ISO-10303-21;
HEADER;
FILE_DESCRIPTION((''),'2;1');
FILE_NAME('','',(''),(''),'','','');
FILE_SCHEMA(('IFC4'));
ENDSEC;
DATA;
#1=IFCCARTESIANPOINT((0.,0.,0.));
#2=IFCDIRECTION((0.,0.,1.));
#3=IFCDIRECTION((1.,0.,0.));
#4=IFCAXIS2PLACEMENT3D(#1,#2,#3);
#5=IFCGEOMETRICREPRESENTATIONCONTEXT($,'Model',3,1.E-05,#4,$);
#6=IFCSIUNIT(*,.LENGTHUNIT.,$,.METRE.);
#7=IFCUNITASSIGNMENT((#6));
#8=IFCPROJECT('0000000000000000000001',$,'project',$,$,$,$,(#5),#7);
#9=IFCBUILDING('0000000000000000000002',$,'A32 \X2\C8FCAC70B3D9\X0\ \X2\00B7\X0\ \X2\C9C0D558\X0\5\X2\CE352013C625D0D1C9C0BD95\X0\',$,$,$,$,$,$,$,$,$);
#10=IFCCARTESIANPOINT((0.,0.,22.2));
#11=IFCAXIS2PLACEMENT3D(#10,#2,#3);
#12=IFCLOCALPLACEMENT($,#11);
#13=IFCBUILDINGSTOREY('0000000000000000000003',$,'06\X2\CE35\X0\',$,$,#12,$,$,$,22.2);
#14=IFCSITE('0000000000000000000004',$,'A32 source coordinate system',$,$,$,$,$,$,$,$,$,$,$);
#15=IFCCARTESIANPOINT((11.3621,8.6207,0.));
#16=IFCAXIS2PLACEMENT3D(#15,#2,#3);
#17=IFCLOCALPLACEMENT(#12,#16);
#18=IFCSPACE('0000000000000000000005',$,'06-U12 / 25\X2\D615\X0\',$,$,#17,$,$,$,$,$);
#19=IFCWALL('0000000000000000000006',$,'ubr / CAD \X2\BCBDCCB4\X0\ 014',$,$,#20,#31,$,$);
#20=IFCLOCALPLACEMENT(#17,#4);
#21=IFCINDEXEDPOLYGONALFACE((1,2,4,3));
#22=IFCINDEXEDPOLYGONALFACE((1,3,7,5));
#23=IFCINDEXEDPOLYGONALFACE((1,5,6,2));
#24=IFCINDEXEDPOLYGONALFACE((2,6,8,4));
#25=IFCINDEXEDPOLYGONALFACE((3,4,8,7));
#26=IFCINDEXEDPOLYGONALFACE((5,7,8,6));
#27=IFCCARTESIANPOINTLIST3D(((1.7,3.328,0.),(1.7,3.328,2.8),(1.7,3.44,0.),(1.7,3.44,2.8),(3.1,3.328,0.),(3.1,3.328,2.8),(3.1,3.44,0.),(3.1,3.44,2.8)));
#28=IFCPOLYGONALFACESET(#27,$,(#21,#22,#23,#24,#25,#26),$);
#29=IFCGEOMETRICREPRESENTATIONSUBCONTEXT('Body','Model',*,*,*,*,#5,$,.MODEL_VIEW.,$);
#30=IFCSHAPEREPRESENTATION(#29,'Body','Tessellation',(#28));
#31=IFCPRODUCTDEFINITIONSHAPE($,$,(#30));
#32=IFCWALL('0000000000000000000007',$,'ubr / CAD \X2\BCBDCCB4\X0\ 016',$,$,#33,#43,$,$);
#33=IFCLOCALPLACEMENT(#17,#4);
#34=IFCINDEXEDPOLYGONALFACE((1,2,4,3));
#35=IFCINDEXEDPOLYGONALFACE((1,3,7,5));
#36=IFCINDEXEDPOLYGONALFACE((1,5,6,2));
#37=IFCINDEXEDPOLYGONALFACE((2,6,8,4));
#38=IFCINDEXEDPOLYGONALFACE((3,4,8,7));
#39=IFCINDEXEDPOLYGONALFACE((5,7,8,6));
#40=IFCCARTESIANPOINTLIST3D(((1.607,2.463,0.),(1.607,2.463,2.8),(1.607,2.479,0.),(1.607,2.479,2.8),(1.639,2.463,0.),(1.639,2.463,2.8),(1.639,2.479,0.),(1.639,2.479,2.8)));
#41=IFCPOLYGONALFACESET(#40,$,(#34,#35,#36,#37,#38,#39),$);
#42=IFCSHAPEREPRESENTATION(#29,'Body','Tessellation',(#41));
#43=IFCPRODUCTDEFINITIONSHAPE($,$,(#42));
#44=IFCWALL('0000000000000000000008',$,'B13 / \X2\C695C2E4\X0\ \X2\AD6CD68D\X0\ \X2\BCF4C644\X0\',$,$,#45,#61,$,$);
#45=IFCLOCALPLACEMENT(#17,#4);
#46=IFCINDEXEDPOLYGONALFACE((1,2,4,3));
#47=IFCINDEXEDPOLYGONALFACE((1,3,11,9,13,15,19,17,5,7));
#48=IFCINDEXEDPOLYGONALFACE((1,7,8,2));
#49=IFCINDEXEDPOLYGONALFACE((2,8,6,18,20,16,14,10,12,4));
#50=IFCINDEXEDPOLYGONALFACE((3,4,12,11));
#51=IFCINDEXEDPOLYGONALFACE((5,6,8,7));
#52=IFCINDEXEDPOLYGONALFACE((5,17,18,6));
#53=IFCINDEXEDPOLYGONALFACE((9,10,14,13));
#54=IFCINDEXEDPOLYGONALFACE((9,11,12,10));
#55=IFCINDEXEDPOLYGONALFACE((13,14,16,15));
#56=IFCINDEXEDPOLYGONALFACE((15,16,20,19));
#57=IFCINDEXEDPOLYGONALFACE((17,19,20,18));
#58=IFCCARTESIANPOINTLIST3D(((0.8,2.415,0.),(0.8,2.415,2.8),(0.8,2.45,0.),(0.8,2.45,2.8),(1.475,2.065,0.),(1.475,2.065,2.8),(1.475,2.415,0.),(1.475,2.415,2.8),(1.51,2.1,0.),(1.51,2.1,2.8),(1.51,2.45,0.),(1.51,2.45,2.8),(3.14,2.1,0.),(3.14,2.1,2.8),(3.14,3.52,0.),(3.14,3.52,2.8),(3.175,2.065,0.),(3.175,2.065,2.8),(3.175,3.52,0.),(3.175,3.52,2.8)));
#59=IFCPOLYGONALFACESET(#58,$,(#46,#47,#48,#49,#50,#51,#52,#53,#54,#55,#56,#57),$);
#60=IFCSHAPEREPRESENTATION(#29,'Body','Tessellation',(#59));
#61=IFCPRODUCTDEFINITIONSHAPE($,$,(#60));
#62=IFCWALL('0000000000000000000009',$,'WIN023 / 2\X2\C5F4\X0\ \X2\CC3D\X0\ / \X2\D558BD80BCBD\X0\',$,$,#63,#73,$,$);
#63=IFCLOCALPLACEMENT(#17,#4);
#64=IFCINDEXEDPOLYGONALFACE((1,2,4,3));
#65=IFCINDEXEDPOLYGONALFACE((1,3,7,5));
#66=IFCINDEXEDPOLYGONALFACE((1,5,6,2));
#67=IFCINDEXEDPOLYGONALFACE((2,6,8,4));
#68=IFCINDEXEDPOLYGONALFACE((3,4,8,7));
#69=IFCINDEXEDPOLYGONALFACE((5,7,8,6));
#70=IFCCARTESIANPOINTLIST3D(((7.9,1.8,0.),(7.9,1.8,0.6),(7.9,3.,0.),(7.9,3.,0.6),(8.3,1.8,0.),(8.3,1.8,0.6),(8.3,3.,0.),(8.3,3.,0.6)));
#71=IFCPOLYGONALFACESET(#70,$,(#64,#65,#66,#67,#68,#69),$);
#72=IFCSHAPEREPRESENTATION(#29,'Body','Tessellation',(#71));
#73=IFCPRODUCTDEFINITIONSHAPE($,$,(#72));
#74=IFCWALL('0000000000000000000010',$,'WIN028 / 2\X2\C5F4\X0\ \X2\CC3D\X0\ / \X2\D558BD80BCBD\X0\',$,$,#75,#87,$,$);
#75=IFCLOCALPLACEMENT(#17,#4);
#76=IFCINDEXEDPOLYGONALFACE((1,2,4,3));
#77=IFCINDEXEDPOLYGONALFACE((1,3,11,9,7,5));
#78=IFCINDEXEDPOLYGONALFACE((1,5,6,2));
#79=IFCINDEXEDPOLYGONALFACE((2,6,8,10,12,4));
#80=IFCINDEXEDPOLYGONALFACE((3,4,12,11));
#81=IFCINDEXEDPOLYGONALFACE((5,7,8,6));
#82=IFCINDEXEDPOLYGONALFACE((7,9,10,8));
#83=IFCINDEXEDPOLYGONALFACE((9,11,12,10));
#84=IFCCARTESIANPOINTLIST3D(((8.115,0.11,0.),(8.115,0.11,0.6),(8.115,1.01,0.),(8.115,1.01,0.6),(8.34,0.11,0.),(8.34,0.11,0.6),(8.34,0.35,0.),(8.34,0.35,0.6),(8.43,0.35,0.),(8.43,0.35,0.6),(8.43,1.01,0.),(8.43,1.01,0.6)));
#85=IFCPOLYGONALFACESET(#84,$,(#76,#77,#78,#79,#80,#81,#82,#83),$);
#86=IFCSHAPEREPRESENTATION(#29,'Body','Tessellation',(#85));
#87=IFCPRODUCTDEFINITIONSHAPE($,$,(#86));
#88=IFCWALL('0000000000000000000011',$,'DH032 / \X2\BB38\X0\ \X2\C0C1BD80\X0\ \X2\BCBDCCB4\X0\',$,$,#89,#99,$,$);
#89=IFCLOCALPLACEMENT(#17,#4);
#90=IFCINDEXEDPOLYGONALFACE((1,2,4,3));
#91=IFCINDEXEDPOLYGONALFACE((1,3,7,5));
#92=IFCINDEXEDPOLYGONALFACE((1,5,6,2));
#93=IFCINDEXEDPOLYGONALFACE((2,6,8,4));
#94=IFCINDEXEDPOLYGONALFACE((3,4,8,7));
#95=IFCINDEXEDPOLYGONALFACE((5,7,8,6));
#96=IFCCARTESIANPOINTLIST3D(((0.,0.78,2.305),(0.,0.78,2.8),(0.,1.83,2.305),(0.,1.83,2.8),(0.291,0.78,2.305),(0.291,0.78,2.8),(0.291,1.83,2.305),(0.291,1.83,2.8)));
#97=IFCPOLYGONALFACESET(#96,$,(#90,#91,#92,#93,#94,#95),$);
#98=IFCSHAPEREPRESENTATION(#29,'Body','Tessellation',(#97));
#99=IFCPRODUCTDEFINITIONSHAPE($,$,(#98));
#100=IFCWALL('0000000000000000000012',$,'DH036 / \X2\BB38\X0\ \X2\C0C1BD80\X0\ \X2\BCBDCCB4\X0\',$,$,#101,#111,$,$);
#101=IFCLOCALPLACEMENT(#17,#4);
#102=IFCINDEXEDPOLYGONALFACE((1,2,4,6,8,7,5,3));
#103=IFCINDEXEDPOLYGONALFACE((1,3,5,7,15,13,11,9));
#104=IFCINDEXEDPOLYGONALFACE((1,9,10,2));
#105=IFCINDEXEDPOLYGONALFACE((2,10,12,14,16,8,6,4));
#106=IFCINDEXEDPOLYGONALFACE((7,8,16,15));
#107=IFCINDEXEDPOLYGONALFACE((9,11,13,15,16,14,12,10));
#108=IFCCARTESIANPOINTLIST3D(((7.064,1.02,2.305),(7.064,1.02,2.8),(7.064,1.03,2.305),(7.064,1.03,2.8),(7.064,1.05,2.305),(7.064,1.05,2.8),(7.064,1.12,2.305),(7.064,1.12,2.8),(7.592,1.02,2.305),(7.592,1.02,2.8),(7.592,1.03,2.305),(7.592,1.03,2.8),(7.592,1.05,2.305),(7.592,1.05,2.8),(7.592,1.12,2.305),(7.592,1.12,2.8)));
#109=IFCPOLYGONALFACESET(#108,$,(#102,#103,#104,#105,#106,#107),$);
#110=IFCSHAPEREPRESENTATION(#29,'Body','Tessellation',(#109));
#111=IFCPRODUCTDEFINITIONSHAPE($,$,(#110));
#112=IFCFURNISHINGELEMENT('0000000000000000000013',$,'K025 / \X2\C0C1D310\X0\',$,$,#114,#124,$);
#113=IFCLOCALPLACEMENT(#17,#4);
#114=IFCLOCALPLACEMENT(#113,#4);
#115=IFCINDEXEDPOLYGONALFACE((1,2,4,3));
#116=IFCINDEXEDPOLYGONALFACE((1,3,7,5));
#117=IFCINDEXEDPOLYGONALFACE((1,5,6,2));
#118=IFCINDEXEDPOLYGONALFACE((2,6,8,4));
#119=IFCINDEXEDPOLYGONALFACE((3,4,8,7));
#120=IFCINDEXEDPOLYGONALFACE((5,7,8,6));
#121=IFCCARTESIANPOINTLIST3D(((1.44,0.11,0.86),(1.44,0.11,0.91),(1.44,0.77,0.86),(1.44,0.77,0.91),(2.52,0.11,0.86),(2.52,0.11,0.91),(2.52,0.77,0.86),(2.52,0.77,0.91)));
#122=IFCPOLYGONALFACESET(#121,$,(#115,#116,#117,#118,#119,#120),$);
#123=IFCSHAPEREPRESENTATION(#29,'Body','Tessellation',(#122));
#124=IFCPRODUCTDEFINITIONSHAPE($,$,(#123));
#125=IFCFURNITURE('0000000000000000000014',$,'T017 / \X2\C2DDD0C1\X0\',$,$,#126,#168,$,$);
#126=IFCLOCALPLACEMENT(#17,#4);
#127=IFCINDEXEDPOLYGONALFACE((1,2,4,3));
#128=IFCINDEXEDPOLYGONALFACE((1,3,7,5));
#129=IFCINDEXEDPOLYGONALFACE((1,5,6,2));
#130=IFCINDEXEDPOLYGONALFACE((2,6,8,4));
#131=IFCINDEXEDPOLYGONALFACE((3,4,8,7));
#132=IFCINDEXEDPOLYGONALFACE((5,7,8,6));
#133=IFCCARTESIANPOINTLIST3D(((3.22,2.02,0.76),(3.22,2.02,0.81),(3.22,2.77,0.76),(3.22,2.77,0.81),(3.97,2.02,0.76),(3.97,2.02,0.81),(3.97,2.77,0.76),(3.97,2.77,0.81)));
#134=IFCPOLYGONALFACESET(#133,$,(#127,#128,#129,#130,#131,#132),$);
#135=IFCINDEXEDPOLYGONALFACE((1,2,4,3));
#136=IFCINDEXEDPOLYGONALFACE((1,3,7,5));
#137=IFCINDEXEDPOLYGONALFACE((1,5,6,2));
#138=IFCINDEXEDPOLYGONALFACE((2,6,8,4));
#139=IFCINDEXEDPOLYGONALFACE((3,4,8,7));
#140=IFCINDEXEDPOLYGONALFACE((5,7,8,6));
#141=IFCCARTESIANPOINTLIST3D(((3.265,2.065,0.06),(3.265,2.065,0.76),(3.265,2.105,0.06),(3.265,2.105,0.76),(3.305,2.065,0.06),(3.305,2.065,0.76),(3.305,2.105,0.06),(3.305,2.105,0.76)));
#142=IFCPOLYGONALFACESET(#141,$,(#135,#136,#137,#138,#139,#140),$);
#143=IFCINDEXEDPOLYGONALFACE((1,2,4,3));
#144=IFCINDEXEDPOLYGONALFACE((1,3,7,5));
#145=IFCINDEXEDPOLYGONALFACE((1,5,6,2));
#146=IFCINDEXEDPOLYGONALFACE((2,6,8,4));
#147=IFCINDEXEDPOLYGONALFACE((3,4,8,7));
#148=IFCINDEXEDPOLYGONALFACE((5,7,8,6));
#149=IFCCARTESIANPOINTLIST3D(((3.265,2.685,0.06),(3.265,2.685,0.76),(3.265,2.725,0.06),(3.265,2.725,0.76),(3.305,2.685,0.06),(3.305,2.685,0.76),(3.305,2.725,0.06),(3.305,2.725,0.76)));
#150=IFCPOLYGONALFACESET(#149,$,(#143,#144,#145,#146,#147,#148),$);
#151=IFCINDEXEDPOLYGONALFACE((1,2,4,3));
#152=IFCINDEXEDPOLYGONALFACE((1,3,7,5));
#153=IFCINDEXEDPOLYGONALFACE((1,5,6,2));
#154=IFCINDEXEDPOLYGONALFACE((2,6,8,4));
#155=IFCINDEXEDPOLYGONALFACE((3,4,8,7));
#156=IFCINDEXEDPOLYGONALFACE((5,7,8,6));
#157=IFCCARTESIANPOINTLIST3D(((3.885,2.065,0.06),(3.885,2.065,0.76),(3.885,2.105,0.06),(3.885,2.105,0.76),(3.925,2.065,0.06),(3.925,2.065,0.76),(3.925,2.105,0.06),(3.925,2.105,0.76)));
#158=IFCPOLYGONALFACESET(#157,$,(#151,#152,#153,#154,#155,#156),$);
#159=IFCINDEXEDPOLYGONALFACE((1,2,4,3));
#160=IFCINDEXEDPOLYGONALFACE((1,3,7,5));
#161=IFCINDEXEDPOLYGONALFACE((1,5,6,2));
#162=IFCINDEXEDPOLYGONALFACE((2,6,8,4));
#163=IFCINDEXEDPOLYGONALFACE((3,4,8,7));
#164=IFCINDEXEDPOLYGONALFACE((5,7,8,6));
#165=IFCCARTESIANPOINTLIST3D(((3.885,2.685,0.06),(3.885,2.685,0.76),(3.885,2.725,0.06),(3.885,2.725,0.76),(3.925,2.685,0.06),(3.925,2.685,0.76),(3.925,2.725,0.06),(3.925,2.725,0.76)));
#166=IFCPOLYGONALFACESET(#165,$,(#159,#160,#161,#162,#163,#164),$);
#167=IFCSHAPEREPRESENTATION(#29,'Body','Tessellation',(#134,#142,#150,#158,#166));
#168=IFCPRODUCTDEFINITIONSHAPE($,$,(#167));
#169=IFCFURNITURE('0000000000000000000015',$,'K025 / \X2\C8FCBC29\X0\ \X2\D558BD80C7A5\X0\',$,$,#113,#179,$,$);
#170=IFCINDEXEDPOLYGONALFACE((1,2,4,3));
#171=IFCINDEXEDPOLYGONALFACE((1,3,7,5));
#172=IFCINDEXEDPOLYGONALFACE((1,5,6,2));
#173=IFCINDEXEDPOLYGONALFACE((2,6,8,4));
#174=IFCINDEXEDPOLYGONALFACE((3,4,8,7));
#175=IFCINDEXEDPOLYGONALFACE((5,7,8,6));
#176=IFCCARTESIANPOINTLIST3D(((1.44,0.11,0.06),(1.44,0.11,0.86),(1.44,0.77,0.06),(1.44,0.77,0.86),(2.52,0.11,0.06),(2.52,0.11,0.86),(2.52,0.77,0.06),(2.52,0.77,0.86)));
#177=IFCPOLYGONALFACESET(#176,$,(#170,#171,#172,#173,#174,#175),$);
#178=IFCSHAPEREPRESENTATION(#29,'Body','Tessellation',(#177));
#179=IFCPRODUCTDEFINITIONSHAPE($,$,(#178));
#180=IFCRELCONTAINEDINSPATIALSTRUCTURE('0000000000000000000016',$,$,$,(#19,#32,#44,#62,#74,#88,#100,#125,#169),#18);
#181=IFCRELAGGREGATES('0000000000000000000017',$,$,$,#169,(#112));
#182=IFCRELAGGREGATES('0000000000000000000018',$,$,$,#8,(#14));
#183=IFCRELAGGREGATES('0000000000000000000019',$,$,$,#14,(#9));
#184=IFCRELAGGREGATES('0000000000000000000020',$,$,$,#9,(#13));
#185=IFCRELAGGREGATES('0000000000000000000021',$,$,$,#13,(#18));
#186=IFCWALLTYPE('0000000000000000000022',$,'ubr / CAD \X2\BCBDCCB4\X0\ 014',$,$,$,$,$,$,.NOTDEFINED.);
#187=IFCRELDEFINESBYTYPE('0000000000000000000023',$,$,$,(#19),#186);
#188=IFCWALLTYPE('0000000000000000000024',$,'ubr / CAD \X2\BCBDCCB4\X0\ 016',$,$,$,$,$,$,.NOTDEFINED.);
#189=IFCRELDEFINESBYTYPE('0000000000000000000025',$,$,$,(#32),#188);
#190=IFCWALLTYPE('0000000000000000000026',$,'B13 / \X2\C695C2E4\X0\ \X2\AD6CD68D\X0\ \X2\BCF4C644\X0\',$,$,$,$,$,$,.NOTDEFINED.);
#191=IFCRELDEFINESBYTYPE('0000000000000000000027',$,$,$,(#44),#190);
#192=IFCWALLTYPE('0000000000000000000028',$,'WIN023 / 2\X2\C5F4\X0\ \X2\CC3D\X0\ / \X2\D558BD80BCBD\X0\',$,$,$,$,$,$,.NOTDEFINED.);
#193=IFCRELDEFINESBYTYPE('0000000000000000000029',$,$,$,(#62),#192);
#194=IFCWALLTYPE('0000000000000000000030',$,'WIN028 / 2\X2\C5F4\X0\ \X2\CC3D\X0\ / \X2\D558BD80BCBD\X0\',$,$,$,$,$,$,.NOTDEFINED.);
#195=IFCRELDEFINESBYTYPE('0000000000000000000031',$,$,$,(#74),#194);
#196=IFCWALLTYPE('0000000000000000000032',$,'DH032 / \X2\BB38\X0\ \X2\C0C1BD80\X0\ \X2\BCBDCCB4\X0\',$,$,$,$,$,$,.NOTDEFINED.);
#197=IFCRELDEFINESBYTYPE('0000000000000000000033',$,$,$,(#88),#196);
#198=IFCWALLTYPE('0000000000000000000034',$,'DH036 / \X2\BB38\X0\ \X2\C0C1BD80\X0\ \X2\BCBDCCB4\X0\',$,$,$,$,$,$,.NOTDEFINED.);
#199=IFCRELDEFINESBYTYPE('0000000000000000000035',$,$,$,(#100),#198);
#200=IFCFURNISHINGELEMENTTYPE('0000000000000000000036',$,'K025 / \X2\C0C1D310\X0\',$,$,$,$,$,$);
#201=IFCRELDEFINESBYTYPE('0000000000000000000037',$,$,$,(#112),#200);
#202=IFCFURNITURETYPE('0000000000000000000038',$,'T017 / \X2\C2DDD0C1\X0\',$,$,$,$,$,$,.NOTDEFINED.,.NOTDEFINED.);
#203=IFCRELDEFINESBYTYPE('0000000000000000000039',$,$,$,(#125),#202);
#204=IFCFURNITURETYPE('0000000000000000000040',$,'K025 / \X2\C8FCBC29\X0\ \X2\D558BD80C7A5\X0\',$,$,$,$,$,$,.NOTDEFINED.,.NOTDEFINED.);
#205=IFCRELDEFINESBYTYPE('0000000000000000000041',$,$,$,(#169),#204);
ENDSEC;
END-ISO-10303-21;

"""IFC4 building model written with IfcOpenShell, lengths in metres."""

from ifc_helpers import new_model, si_unit, frame, origin, origin_with_axes, place, context, subcontext, project, spatial, polyline, outline, extrude, source, transform, mapped, type_object, type_shapes, element, aggregate, save


model = new_model("IFC4")

# Units and contexts
model_context = context("Model", 3, precision=1e-05, world=origin_with_axes())
body_context = subcontext(model_context, "Body", "Model", "MODEL_VIEW")
ifc_project = project(units=[si_unit("LENGTHUNIT", "METRE")], contexts=[model_context])

# Site, building, storey, space
site = spatial("IfcSite", under=ifc_project, Name="A32 source coordinate system")
building = spatial("IfcBuilding", under=site, Name="A32 주거동 · 지하5층–옥탑지붕")
storey_placement = place(None, frame((0.0, 0.0, 22.2), z_axis=(0.0, 0.0, 1.0), x_axis=(1.0, 0.0, 0.0)))
storey = spatial("IfcBuildingStorey", under=building, at=storey_placement, Name="06층", Elevation=22.2)
space_1_placement = place(storey_placement, frame((11.3621, 8.6207, 0.0), z_axis=(0.0, 0.0, 1.0), x_axis=(1.0, 0.0, 0.0)))
space_1 = spatial("IfcSpace", under=storey, at=space_1_placement, Name="06-U12 / 25형")

# Walls
wall_type_1 = type_object("IfcWallType", Name="ubr / CAD 벽체 014", PredefinedType="NOTDEFINED")
shared_shape_1 = source(origin(), body_context, "Body", "SweptSolid", [
    extrude(outline(polyline([(3.1, 3.44), (3.1, 3.328), (1.7, 3.328), (1.7, 3.44), (3.1, 3.44)])), origin(), (0.0, 0.0, 1.0), 2.8),
])
type_shapes(wall_type_1, [shared_shape_1])
wall_1_placement = place(space_1_placement, origin_with_axes())
element("IfcWall", 1, at=wall_1_placement, inside=space_1, type_object=wall_type_1, Name="ubr / CAD 벽체 014", context=body_context, shape_type="MappedRepresentation", body=[
    mapped(shared_shape_1, transform((0.0, 0.0, 0.0), scale=1.0)),
])
wall_type_2 = type_object("IfcWallType", Name="ubr / CAD 벽체 016", PredefinedType="NOTDEFINED")
shared_shape_2 = source(origin(), body_context, "Body", "SweptSolid", [
    extrude(outline(polyline([(1.639, 2.479), (1.639, 2.463), (1.607, 2.463), (1.607, 2.479), (1.639, 2.479)])), origin(), (0.0, 0.0, 1.0), 2.8),
])
type_shapes(wall_type_2, [shared_shape_2])
wall_2_placement = place(space_1_placement, origin_with_axes())
element("IfcWall", 2, at=wall_2_placement, inside=space_1, type_object=wall_type_2, Name="ubr / CAD 벽체 016", context=body_context, shape_type="MappedRepresentation", body=[
    mapped(shared_shape_2, transform((0.0, 0.0, 0.0), scale=1.0)),
])
wall_type_3 = type_object("IfcWallType", Name="B13 / 욕실 구획 보완", PredefinedType="NOTDEFINED")
shared_shape_3 = source(origin(), body_context, "Body", "SweptSolid", [
    extrude(outline(polyline([(0.8, 2.45), (1.51, 2.45), (1.51, 2.1), (3.14, 2.1), (3.14, 3.52), (3.175, 3.52), (3.175, 2.065), (1.475, 2.065), (1.475, 2.415), (0.8, 2.415), (0.8, 2.45)])), origin(), (0.0, 0.0, 1.0), 2.8),
])
type_shapes(wall_type_3, [shared_shape_3])
wall_3_placement = place(space_1_placement, origin_with_axes())
element("IfcWall", 3, at=wall_3_placement, inside=space_1, type_object=wall_type_3, Name="B13 / 욕실 구획 보완", context=body_context, shape_type="MappedRepresentation", body=[
    mapped(shared_shape_3, transform((0.0, 0.0, 0.0), scale=1.0)),
])
wall_type_4 = type_object("IfcWallType", Name="WIN023 / 2열 창 / 하부벽", PredefinedType="NOTDEFINED")
shared_shape_4 = source(origin(), body_context, "Body", "SweptSolid", [
    extrude(outline(polyline([(7.9, 1.8), (7.9, 3.0), (8.3, 3.0), (8.3, 1.8), (7.9, 1.8)])), origin(), (0.0, 0.0, 1.0), 0.6),
])
type_shapes(wall_type_4, [shared_shape_4])
wall_4_placement = place(space_1_placement, origin_with_axes())
element("IfcWall", 4, at=wall_4_placement, inside=space_1, type_object=wall_type_4, Name="WIN023 / 2열 창 / 하부벽", context=body_context, shape_type="MappedRepresentation", body=[
    mapped(shared_shape_4, transform((0.0, 0.0, 0.0), scale=1.0)),
])
wall_type_5 = type_object("IfcWallType", Name="WIN028 / 2열 창 / 하부벽", PredefinedType="NOTDEFINED")
shared_shape_5 = source(origin(), body_context, "Body", "SweptSolid", [
    extrude(outline(polyline([(8.34, 0.35), (8.34, 0.11), (8.115, 0.11), (8.115, 1.01), (8.43, 1.01), (8.43, 0.35), (8.34, 0.35)])), origin(), (0.0, 0.0, 1.0), 0.6),
])
type_shapes(wall_type_5, [shared_shape_5])
wall_5_placement = place(space_1_placement, origin_with_axes())
element("IfcWall", 5, at=wall_5_placement, inside=space_1, type_object=wall_type_5, Name="WIN028 / 2열 창 / 하부벽", context=body_context, shape_type="MappedRepresentation", body=[
    mapped(shared_shape_5, transform((0.0, 0.0, 0.0), scale=1.0)),
])
wall_type_6 = type_object("IfcWallType", Name="DH032 / 문 상부 벽체", PredefinedType="NOTDEFINED")
shared_shape_6 = source(origin(), body_context, "Body", "SweptSolid", [
    extrude(outline(polyline([(0.0, 1.83), (0.291, 1.83), (0.291, 0.78), (0.0, 0.78), (0.0, 1.83)])), frame((0.0, 0.0, 2.305)), (0.0, 0.0, 1.0), 0.495),
])
type_shapes(wall_type_6, [shared_shape_6])
wall_6_placement = place(space_1_placement, origin_with_axes())
element("IfcWall", 6, at=wall_6_placement, inside=space_1, type_object=wall_type_6, Name="DH032 / 문 상부 벽체", context=body_context, shape_type="MappedRepresentation", body=[
    mapped(shared_shape_6, transform((0.0, 0.0, 0.0), scale=1.0)),
])
wall_type_7 = type_object("IfcWallType", Name="DH036 / 문 상부 벽체", PredefinedType="NOTDEFINED")
shared_shape_7 = source(origin(), body_context, "Body", "SweptSolid", [
    extrude(outline(polyline([(7.064, 1.03), (7.064, 1.05), (7.064, 1.12), (7.592, 1.12), (7.592, 1.05), (7.592, 1.03), (7.592, 1.02), (7.064, 1.02), (7.064, 1.03)])), frame((0.0, 0.0, 2.305)), (0.0, 0.0, 1.0), 0.495),
])
type_shapes(wall_type_7, [shared_shape_7])
wall_7_placement = place(space_1_placement, origin_with_axes())
element("IfcWall", 7, at=wall_7_placement, inside=space_1, type_object=wall_type_7, Name="DH036 / 문 상부 벽체", context=body_context, shape_type="MappedRepresentation", body=[
    mapped(shared_shape_7, transform((0.0, 0.0, 0.0), scale=1.0)),
])

# Furnishing element
furnishing_element_type_1 = type_object("IfcFurnishingElementType", Name="K025 / 상판")
shared_shape_8 = source(origin(), body_context, "Body", "SweptSolid", [
    extrude(outline(polyline([(2.52, 0.77), (2.52, 0.11), (1.44, 0.11), (1.44, 0.77), (2.52, 0.77)])), frame((0.0, 0.0, 0.86)), (0.0, 0.0, 1.0), 0.05),
])
type_shapes(furnishing_element_type_1, [shared_shape_8])
furniture_1_placement = place(space_1_placement, origin_with_axes())
furnishing_1_placement = place(furniture_1_placement, origin_with_axes())
furnishing_1 = element("IfcFurnishingElement", 8, at=furnishing_1_placement, type_object=furnishing_element_type_1, Name="K025 / 상판", context=body_context, shape_type="MappedRepresentation", body=[
    mapped(shared_shape_8, transform((0.0, 0.0, 0.0), scale=1.0)),
])

# Furniture
furniture_type_1 = type_object("IfcFurnitureType", Name="T017 / 식탁", AssemblyPlace="NOTDEFINED", PredefinedType="NOTDEFINED")
shared_shape_9 = source(origin(), body_context, "Body", "SweptSolid", [
    extrude(outline(polyline([(3.97, 2.02), (3.22, 2.02), (3.22, 2.77), (3.97, 2.77), (3.97, 2.02)])), frame((0.0, 0.0, 0.76)), (0.0, 0.0, 1.0), 0.05),
    extrude(outline(polyline([(3.265, 2.065), (3.265, 2.105), (3.305, 2.105), (3.305, 2.065), (3.265, 2.065)])), frame((0.0, 0.0, 0.06)), (0.0, 0.0, 1.0), 0.7),
    extrude(outline(polyline([(3.265, 2.685), (3.265, 2.725), (3.305, 2.725), (3.305, 2.685), (3.265, 2.685)])), frame((0.0, 0.0, 0.06)), (0.0, 0.0, 1.0), 0.7),
    extrude(outline(polyline([(3.885, 2.065), (3.885, 2.105), (3.925, 2.105), (3.925, 2.065), (3.885, 2.065)])), frame((0.0, 0.0, 0.06)), (0.0, 0.0, 1.0), 0.7),
    extrude(outline(polyline([(3.885, 2.685), (3.885, 2.725), (3.925, 2.725), (3.925, 2.685), (3.885, 2.685)])), frame((0.0, 0.0, 0.06)), (0.0, 0.0, 1.0), 0.7),
])
type_shapes(furniture_type_1, [shared_shape_9])
furniture_2_placement = place(space_1_placement, origin_with_axes())
element("IfcFurniture", 9, at=furniture_2_placement, inside=space_1, type_object=furniture_type_1, Name="T017 / 식탁", context=body_context, shape_type="MappedRepresentation", body=[
    mapped(shared_shape_9, transform((0.0, 0.0, 0.0), scale=1.0)),
])
furniture_type_2 = type_object("IfcFurnitureType", Name="K025 / 주방 하부장", AssemblyPlace="NOTDEFINED", PredefinedType="NOTDEFINED")
shared_shape_10 = source(origin(), body_context, "Body", "SweptSolid", [
    extrude(outline(polyline([(1.44, 0.77), (2.52, 0.77), (2.52, 0.11), (1.44, 0.11), (1.44, 0.77)])), frame((0.0, 0.0, 0.06)), (0.0, 0.0, 1.0), 0.8),
])
type_shapes(furniture_type_2, [shared_shape_10])
furniture_1 = element("IfcFurniture", 10, at=furniture_1_placement, inside=space_1, type_object=furniture_type_2, Name="K025 / 주방 하부장", context=body_context, shape_type="MappedRepresentation", body=[
    mapped(shared_shape_10, transform((0.0, 0.0, 0.0), scale=1.0)),
])
aggregate(furniture_1, [furnishing_1])

save(model, "model.ifc")
